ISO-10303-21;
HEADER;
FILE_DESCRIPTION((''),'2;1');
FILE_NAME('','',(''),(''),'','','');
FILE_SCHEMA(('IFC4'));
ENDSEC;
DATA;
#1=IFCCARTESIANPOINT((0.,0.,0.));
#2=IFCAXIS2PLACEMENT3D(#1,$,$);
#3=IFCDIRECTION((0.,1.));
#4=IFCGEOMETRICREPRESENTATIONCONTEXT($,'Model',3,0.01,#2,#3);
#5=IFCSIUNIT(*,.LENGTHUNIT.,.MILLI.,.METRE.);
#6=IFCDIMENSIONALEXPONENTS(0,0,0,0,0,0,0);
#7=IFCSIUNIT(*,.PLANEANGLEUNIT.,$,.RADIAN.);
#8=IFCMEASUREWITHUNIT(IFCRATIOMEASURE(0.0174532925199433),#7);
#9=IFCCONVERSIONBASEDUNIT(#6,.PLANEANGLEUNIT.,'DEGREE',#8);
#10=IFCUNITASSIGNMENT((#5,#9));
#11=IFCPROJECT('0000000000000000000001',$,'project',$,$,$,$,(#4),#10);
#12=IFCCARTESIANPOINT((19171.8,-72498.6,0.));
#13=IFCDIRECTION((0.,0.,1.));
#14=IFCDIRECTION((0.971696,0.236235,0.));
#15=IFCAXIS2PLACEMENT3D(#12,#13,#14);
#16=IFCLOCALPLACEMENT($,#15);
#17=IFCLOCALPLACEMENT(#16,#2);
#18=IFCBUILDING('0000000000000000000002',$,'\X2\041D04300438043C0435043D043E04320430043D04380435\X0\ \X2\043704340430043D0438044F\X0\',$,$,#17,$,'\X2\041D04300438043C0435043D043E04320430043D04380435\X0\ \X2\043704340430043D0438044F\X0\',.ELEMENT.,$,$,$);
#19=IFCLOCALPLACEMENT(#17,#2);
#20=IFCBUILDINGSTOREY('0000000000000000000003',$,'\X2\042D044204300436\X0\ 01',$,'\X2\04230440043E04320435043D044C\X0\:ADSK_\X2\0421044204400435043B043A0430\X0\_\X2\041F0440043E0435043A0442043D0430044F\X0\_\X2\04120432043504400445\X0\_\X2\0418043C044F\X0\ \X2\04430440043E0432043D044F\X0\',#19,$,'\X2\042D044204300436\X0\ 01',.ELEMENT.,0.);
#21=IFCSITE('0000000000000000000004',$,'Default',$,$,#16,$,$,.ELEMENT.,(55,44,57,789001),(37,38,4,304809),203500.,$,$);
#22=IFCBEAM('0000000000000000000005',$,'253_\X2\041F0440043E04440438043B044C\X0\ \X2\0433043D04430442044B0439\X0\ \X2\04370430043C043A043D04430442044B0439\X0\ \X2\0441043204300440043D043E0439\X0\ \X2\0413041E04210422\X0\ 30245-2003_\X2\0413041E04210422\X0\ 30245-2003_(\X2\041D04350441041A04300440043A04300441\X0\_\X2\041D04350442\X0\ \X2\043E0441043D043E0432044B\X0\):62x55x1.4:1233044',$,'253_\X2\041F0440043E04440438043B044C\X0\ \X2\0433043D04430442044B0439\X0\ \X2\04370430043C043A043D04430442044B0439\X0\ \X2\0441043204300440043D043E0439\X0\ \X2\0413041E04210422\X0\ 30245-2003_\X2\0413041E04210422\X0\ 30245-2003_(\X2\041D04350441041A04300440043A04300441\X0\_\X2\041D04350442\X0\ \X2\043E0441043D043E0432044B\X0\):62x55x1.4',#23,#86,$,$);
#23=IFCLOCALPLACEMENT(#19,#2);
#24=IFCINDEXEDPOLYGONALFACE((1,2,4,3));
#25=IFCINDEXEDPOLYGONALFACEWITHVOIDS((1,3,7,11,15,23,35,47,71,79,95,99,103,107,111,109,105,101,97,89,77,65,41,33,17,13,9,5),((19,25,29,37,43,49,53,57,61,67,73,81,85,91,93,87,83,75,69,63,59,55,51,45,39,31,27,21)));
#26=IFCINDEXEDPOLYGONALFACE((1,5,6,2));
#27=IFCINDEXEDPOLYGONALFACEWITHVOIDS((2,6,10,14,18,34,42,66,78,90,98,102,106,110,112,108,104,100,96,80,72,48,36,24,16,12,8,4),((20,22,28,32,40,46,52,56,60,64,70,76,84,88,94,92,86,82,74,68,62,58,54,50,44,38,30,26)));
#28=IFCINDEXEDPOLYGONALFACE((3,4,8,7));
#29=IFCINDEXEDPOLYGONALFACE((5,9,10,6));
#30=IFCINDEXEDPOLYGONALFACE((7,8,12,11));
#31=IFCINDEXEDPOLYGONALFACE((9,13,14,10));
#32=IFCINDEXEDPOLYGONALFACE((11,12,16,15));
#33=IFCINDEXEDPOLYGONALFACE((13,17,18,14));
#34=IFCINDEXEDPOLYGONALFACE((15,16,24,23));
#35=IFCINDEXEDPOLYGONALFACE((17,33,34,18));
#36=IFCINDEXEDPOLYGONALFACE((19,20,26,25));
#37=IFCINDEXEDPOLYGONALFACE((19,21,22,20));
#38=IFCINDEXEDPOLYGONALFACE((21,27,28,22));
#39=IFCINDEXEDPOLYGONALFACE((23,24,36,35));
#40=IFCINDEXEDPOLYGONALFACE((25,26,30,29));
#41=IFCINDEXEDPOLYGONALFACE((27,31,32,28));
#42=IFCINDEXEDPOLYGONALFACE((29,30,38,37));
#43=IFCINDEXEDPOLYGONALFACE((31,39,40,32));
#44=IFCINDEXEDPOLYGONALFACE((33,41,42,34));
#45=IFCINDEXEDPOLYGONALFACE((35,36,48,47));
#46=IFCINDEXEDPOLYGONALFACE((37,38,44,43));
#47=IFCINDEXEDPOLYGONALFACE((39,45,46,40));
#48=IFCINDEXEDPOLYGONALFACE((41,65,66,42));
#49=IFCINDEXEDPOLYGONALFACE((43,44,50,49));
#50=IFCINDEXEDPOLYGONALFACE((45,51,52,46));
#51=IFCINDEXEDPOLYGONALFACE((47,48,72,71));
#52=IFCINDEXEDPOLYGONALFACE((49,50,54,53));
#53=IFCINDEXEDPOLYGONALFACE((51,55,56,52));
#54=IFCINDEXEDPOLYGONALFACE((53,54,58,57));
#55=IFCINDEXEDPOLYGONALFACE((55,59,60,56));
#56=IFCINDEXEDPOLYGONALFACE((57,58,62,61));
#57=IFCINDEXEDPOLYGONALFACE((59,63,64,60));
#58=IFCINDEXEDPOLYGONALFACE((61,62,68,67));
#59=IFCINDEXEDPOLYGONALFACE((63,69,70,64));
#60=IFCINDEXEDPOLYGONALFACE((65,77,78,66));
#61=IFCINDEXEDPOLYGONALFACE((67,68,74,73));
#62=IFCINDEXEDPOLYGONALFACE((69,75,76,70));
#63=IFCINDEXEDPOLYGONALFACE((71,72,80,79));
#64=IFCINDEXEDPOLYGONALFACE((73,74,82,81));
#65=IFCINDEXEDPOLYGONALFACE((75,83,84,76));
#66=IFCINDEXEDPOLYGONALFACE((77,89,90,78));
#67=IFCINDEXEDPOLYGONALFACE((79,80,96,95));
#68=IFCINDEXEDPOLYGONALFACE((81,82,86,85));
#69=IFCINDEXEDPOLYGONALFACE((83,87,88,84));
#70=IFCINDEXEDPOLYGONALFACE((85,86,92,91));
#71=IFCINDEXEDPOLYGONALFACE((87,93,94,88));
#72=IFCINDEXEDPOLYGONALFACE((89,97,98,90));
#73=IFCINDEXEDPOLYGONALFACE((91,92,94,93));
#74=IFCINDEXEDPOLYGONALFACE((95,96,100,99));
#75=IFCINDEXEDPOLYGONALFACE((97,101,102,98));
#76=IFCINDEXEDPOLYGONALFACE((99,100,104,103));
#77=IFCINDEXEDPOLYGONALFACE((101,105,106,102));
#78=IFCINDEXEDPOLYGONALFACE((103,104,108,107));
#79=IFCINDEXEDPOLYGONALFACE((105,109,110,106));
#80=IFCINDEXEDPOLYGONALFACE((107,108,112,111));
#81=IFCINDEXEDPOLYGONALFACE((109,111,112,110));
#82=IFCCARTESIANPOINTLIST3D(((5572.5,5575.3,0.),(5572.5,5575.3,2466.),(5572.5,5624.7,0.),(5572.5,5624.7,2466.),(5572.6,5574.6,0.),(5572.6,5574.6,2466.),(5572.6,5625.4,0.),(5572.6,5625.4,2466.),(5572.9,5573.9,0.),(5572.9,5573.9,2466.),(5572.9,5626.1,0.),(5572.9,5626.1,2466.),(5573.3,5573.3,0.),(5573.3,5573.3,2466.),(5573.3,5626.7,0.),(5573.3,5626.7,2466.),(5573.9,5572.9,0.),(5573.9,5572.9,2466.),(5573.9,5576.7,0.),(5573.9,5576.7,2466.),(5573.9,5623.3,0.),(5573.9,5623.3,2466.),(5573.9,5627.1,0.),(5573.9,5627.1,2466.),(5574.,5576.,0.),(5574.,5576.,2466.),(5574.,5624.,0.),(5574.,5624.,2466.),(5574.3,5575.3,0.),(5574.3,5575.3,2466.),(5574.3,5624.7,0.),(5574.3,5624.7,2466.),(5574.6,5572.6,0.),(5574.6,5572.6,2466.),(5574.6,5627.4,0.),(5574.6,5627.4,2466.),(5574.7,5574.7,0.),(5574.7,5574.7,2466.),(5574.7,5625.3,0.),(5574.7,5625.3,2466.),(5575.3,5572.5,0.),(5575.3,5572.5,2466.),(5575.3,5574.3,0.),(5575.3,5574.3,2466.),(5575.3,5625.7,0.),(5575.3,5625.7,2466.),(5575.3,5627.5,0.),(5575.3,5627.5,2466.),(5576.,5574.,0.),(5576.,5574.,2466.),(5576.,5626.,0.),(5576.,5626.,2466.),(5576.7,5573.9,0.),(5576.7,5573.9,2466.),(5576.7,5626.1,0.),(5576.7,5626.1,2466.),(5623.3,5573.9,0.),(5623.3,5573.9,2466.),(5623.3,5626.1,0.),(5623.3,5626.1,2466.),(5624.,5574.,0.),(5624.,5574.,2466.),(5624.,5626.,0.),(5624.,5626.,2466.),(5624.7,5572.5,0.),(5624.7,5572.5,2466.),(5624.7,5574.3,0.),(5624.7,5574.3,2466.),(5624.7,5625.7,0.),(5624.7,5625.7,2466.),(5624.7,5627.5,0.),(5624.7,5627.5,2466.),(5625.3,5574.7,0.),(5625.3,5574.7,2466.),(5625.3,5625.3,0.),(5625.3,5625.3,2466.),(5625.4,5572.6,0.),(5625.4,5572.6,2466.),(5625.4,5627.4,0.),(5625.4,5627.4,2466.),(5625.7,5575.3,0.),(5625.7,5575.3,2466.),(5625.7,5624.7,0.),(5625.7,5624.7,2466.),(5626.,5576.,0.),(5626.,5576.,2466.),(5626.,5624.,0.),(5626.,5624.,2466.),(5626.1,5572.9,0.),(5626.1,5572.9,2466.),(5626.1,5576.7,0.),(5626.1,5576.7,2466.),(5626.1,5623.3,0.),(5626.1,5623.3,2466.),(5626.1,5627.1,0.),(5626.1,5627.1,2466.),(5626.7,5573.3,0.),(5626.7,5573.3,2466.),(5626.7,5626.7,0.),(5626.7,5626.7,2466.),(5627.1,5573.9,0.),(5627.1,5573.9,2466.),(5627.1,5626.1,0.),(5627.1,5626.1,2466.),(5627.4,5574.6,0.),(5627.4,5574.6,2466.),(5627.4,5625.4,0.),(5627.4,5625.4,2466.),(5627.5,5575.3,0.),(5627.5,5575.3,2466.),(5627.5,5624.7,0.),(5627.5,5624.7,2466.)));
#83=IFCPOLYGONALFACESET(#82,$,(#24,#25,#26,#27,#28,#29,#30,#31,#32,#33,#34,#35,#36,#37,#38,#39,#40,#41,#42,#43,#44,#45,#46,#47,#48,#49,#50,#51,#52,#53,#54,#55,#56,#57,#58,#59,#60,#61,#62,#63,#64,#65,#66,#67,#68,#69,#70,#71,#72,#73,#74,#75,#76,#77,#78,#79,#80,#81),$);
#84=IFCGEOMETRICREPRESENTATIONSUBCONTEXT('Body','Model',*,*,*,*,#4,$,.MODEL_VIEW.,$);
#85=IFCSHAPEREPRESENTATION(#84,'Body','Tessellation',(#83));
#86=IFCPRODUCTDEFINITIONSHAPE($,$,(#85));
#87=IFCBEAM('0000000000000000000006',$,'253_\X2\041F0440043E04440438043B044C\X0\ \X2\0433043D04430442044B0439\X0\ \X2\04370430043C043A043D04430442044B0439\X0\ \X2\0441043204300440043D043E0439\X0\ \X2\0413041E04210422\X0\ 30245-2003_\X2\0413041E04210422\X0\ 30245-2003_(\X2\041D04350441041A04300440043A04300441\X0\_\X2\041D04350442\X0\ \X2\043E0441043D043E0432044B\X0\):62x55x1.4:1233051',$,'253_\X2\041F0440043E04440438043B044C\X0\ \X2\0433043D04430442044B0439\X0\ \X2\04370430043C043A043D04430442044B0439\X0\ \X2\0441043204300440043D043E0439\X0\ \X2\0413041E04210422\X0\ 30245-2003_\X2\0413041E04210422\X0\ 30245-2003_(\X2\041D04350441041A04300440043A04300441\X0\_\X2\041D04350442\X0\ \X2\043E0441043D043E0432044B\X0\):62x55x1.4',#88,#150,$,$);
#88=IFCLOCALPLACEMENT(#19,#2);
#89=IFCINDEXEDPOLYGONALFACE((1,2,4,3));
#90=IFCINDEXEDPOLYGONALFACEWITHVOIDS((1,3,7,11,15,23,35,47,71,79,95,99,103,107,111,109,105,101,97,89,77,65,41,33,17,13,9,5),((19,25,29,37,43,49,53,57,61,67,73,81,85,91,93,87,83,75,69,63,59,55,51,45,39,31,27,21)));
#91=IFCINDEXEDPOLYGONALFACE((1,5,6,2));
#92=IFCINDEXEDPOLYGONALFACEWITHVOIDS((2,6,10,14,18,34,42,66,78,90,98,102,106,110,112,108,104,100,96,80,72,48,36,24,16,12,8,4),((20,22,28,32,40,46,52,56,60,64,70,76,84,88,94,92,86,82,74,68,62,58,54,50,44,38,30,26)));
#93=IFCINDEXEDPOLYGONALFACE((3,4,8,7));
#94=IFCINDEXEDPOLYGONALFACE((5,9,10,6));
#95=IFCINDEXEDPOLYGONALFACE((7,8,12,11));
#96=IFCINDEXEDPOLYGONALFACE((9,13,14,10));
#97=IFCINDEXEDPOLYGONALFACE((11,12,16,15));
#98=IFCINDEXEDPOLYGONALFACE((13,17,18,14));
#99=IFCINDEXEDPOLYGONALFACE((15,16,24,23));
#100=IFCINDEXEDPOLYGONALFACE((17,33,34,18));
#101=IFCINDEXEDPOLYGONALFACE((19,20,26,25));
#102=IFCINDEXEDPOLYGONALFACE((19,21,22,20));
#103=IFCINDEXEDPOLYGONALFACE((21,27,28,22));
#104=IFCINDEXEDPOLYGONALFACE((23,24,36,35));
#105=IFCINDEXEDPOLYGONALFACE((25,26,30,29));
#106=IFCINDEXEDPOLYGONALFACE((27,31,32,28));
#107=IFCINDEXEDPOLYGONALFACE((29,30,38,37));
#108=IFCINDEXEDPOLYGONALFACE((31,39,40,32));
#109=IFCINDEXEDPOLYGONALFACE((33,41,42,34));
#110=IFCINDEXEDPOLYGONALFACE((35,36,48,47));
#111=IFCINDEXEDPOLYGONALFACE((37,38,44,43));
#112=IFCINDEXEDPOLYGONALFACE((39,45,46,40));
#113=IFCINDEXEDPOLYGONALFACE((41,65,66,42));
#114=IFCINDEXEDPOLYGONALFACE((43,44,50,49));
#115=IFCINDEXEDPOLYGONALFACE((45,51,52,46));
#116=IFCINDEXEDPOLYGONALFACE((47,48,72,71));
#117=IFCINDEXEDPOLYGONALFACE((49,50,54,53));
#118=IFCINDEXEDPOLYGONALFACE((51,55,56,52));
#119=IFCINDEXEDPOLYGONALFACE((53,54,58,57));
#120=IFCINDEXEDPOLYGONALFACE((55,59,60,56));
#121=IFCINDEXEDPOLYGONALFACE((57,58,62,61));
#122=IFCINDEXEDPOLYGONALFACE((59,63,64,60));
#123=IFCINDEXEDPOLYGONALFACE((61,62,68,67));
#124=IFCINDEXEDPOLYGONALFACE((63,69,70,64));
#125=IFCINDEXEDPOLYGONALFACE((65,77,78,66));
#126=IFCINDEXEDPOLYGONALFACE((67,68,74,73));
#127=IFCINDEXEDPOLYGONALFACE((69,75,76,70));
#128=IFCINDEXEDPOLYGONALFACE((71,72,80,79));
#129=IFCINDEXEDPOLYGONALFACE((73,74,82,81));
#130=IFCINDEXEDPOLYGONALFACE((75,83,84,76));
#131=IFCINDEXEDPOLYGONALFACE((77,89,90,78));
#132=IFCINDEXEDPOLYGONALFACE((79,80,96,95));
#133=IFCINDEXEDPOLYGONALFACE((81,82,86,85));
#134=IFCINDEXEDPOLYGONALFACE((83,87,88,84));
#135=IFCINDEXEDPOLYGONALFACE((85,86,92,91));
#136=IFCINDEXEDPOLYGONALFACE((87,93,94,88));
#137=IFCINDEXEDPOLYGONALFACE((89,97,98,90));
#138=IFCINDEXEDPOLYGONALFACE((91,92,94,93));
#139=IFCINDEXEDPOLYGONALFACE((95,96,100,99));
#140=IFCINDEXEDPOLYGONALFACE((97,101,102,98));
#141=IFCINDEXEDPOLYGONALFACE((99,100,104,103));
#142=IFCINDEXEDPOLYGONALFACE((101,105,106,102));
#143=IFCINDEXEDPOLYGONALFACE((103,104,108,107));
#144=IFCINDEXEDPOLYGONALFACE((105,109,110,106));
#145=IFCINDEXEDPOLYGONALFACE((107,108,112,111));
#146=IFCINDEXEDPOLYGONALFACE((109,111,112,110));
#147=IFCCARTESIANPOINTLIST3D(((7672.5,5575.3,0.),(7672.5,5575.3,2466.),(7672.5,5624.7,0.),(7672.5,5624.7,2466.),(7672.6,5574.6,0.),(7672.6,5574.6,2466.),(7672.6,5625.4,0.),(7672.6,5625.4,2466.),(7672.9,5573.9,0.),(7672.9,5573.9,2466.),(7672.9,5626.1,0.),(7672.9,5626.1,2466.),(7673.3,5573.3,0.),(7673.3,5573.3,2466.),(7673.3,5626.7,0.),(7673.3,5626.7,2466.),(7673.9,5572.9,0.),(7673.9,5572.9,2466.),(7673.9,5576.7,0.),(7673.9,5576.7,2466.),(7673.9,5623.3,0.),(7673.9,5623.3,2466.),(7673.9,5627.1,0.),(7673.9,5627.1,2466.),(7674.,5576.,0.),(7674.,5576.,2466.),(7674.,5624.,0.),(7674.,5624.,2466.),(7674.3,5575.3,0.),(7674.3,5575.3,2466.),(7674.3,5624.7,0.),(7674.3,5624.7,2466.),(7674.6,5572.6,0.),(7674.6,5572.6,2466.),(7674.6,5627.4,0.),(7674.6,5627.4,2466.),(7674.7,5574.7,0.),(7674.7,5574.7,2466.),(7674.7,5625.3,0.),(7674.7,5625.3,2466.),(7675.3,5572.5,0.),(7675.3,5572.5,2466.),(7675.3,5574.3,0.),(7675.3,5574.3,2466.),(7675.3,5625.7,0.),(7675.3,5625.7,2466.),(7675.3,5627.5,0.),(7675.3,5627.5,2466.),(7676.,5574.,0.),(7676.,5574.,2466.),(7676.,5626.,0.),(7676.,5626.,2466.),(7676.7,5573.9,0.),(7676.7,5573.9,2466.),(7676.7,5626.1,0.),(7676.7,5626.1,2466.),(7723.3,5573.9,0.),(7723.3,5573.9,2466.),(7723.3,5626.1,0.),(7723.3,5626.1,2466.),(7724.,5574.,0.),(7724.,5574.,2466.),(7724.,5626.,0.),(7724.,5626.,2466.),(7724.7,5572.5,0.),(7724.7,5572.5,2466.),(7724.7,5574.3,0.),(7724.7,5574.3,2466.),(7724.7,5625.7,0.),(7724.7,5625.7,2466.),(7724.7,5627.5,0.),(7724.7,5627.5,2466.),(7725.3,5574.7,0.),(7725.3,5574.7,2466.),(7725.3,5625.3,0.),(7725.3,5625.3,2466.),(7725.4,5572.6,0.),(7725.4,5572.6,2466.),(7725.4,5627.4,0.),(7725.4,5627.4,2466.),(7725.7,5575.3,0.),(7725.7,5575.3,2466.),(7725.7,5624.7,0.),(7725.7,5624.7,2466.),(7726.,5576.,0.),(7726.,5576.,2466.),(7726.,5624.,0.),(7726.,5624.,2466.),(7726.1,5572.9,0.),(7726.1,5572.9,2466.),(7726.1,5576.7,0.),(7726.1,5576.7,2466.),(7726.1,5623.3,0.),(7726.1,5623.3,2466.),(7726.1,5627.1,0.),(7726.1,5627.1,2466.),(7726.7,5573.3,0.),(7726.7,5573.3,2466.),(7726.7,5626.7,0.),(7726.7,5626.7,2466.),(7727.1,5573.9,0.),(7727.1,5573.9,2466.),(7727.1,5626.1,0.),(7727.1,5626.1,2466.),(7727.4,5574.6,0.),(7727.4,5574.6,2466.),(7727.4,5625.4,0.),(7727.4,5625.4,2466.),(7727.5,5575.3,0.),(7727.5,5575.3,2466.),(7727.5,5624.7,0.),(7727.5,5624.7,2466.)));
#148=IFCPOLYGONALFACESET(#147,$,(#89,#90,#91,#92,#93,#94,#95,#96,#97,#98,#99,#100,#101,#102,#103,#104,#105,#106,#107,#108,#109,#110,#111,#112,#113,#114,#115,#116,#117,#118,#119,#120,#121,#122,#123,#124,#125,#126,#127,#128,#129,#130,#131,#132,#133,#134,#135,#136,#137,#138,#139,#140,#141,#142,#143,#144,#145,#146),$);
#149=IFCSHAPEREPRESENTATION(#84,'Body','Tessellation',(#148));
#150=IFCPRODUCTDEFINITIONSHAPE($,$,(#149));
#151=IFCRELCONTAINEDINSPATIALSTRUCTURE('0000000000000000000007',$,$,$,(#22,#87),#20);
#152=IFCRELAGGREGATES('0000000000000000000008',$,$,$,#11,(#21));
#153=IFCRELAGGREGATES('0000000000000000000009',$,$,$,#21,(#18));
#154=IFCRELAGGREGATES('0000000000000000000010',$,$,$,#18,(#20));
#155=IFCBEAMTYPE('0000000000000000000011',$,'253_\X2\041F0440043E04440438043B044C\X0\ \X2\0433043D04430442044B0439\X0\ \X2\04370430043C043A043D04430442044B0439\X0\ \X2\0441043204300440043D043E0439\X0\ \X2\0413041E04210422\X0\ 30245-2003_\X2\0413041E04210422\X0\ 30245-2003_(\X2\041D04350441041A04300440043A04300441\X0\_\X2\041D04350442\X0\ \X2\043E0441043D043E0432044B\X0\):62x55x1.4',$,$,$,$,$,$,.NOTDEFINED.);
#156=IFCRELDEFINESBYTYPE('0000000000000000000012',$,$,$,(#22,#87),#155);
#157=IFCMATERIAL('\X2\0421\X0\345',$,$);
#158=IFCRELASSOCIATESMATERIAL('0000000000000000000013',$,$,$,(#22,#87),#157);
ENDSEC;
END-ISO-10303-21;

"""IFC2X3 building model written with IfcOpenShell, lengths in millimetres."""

from ifc_helpers import new_model, entity, si_unit, converted_unit, direction, frame, frame_2d, origin, place, context, subcontext, project, spatial, polyline, circle_curve, parameter, trimmed, segment, composite_curve, outline, extrude, material, type_object, element, save


model = new_model("IFC2X3")

# Units and contexts
model_context = context("Model", 3, precision=0.01, world=origin(), true_north=direction((0.0, 1.0)))
body_context = subcontext(model_context, "Body", "Model", "MODEL_VIEW")
ifc_project = project(units=[si_unit("LENGTHUNIT", "METRE", prefix="MILLI"), converted_unit("PLANEANGLEUNIT", "DEGREE", entity("IfcRatioMeasure", 0.0174532925199433), si_unit("PLANEANGLEUNIT", "RADIAN"), dimensions=[0, 0, 0, 0, 0, 0, 0])], contexts=[model_context])

# Site, building, storey
site_placement = place(None, frame((19171.8, -72498.6, 0.0), z_axis=(0.0, 0.0, 1.0), x_axis=(0.971696, 0.236235, 0.0)))
site = spatial("IfcSite", under=ifc_project, at=site_placement, Name="Default", CompositionType="ELEMENT", RefLatitude=(55, 44, 57, 789001), RefLongitude=(37, 38, 4, 304809), RefElevation=203500.0)
building_placement = place(site_placement, origin())
building = spatial("IfcBuilding", under=site, at=building_placement, Name="Наименование здания", LongName="Наименование здания", CompositionType="ELEMENT")
storey_placement = place(building_placement, origin())
storey = spatial("IfcBuildingStorey", under=building, at=storey_placement, Name="Этаж 01", ObjectType="Уровень:ADSK_Стрелка_Проектная_Вверх_Имя уровня", LongName="Этаж 01", CompositionType="ELEMENT", Elevation=0.0)

# Beams
ifc_material_1 = material(Name="С345")
beam_type_1 = type_object("IfcBeamType", Name="253_Профиль гнутый замкнутый сварной ГОСТ 30245-2003_ГОСТ 30245-2003_(НесКаркас_Нет основы):62x55x1.4", PredefinedType="NOTDEFINED")
beam_1_placement = place(storey_placement, frame((5570.9, 5570.9, 0.0), z_axis=(1.0, 0.0, 0.0), x_axis=(0.0, 0.0, -1.0)))
element("IfcBeam", 1, at=beam_1_placement, inside=storey, type_object=beam_type_1, material=ifc_material_1, Name="253_Профиль гнутый замкнутый сварной ГОСТ 30245-2003_ГОСТ 30245-2003_(НесКаркас_Нет основы):62x55x1.4:1233044", ObjectType="253_Профиль гнутый замкнутый сварной ГОСТ 30245-2003_ГОСТ 30245-2003_(НесКаркас_Нет основы):62x55x1.4", context=body_context, shape_type="SweptSolid", body=[
    extrude(outline(composite_curve([segment(trimmed(circle_curve(frame_2d((24.7, -24.7), x_axis=(1.0, 0.0)), 2.8), [parameter(270.0)], [parameter(0.0)], True, "PARAMETER"), True, "CONTINUOUS"), segment(polyline([(27.5, -24.7), (27.5, 24.7)]), True, "CONTINUOUS"), segment(trimmed(circle_curve(frame_2d((24.7, 24.7), x_axis=(1.0, 0.0)), 2.8), [parameter(0.0)], [parameter(90.0)], True, "PARAMETER"), True, "CONTINUOUS"), segment(polyline([(24.7, 27.5), (-24.7, 27.5)]), True, "CONTINUOUS"), segment(trimmed(circle_curve(frame_2d((-24.7, 24.7), x_axis=(1.0, 0.0)), 2.8), [parameter(90.0)], [parameter(180.0)], True, "PARAMETER"), True, "CONTINUOUS"), segment(polyline([(-27.5, 24.7), (-27.5, -24.7)]), True, "CONTINUOUS"), segment(trimmed(circle_curve(frame_2d((-24.7, -24.7), x_axis=(1.0, 0.0)), 2.8), [parameter(180.0)], [parameter(270.0)], True, "PARAMETER"), True, "CONTINUOUS"), segment(polyline([(-24.7, -27.5), (24.7, -27.5)]), True, "CONTINUOUS")], self_intersect=False), holes=[composite_curve([segment(polyline([(23.3, -26.1), (-23.3, -26.1)]), True, "CONTINUOUS"), segment(trimmed(circle_curve(frame_2d((-23.3, -23.3), x_axis=(1.0, 0.0)), 2.8), [parameter(180.0)], [parameter(270.0)], True, "PARAMETER"), False, "CONTINUOUS"), segment(polyline([(-26.1, -23.3), (-26.1, 23.3)]), True, "CONTINUOUS"), segment(trimmed(circle_curve(frame_2d((-23.3, 23.3), x_axis=(1.0, 0.0)), 2.8), [parameter(90.0)], [parameter(180.0)], True, "PARAMETER"), False, "CONTINUOUS"), segment(polyline([(-23.3, 26.1), (23.3, 26.1)]), True, "CONTINUOUS"), segment(trimmed(circle_curve(frame_2d((23.3, 23.3), x_axis=(1.0, 0.0)), 2.8), [parameter(0.0)], [parameter(90.0)], True, "PARAMETER"), False, "CONTINUOUS"), segment(polyline([(26.1, 23.3), (26.1, -23.3)]), True, "CONTINUOUS"), segment(trimmed(circle_curve(frame_2d((23.3, -23.3), x_axis=(1.0, 0.0)), 2.8), [parameter(270.0)], [parameter(0.0)], True, "PARAMETER"), False, "CONTINUOUS")], self_intersect=False)]), frame((-2466.0, 29.1, 29.1), z_axis=(1.0, 0.0, 0.0), x_axis=(0.0, 1.0, 0.0)), (0.0, 0.0, 1.0), 2466.0),
])
beam_2_placement = place(storey_placement, frame((7670.9, 5570.9, 0.0), z_axis=(1.0, 0.0, 0.0), x_axis=(0.0, 0.0, -1.0)))
element("IfcBeam", 2, at=beam_2_placement, inside=storey, type_object=beam_type_1, material=ifc_material_1, Name="253_Профиль гнутый замкнутый сварной ГОСТ 30245-2003_ГОСТ 30245-2003_(НесКаркас_Нет основы):62x55x1.4:1233051", ObjectType="253_Профиль гнутый замкнутый сварной ГОСТ 30245-2003_ГОСТ 30245-2003_(НесКаркас_Нет основы):62x55x1.4", context=body_context, shape_type="SweptSolid", body=[
    extrude(outline(composite_curve([segment(trimmed(circle_curve(frame_2d((24.7, -24.7), x_axis=(1.0, 0.0)), 2.8), [parameter(270.0)], [parameter(0.0)], True, "PARAMETER"), True, "CONTINUOUS"), segment(polyline([(27.5, -24.7), (27.5, 24.7)]), True, "CONTINUOUS"), segment(trimmed(circle_curve(frame_2d((24.7, 24.7), x_axis=(1.0, 0.0)), 2.8), [parameter(0.0)], [parameter(90.0)], True, "PARAMETER"), True, "CONTINUOUS"), segment(polyline([(24.7, 27.5), (-24.7, 27.5)]), True, "CONTINUOUS"), segment(trimmed(circle_curve(frame_2d((-24.7, 24.7), x_axis=(1.0, 0.0)), 2.8), [parameter(90.0)], [parameter(180.0)], True, "PARAMETER"), True, "CONTINUOUS"), segment(polyline([(-27.5, 24.7), (-27.5, -24.7)]), True, "CONTINUOUS"), segment(trimmed(circle_curve(frame_2d((-24.7, -24.7), x_axis=(1.0, 0.0)), 2.8), [parameter(180.0)], [parameter(270.0)], True, "PARAMETER"), True, "CONTINUOUS"), segment(polyline([(-24.7, -27.5), (24.7, -27.5)]), True, "CONTINUOUS")], self_intersect=False), holes=[composite_curve([segment(polyline([(23.3, -26.1), (-23.3, -26.1)]), True, "CONTINUOUS"), segment(trimmed(circle_curve(frame_2d((-23.3, -23.3), x_axis=(1.0, 0.0)), 2.8), [parameter(180.0)], [parameter(270.0)], True, "PARAMETER"), False, "CONTINUOUS"), segment(polyline([(-26.1, -23.3), (-26.1, 23.3)]), True, "CONTINUOUS"), segment(trimmed(circle_curve(frame_2d((-23.3, 23.3), x_axis=(1.0, 0.0)), 2.8), [parameter(90.0)], [parameter(180.0)], True, "PARAMETER"), False, "CONTINUOUS"), segment(polyline([(-23.3, 26.1), (23.3, 26.1)]), True, "CONTINUOUS"), segment(trimmed(circle_curve(frame_2d((23.3, 23.3), x_axis=(1.0, 0.0)), 2.8), [parameter(0.0)], [parameter(90.0)], True, "PARAMETER"), False, "CONTINUOUS"), segment(polyline([(26.1, 23.3), (26.1, -23.3)]), True, "CONTINUOUS"), segment(trimmed(circle_curve(frame_2d((23.3, -23.3), x_axis=(1.0, 0.0)), 2.8), [parameter(270.0)], [parameter(0.0)], True, "PARAMETER"), False, "CONTINUOUS")], self_intersect=False)]), frame((-2466.0, 29.1, 29.1), z_axis=(1.0, 0.0, 0.0), x_axis=(0.0, 1.0, 0.0)), (0.0, 0.0, 1.0), 2466.0),
])

save(model, "model.ifc")
